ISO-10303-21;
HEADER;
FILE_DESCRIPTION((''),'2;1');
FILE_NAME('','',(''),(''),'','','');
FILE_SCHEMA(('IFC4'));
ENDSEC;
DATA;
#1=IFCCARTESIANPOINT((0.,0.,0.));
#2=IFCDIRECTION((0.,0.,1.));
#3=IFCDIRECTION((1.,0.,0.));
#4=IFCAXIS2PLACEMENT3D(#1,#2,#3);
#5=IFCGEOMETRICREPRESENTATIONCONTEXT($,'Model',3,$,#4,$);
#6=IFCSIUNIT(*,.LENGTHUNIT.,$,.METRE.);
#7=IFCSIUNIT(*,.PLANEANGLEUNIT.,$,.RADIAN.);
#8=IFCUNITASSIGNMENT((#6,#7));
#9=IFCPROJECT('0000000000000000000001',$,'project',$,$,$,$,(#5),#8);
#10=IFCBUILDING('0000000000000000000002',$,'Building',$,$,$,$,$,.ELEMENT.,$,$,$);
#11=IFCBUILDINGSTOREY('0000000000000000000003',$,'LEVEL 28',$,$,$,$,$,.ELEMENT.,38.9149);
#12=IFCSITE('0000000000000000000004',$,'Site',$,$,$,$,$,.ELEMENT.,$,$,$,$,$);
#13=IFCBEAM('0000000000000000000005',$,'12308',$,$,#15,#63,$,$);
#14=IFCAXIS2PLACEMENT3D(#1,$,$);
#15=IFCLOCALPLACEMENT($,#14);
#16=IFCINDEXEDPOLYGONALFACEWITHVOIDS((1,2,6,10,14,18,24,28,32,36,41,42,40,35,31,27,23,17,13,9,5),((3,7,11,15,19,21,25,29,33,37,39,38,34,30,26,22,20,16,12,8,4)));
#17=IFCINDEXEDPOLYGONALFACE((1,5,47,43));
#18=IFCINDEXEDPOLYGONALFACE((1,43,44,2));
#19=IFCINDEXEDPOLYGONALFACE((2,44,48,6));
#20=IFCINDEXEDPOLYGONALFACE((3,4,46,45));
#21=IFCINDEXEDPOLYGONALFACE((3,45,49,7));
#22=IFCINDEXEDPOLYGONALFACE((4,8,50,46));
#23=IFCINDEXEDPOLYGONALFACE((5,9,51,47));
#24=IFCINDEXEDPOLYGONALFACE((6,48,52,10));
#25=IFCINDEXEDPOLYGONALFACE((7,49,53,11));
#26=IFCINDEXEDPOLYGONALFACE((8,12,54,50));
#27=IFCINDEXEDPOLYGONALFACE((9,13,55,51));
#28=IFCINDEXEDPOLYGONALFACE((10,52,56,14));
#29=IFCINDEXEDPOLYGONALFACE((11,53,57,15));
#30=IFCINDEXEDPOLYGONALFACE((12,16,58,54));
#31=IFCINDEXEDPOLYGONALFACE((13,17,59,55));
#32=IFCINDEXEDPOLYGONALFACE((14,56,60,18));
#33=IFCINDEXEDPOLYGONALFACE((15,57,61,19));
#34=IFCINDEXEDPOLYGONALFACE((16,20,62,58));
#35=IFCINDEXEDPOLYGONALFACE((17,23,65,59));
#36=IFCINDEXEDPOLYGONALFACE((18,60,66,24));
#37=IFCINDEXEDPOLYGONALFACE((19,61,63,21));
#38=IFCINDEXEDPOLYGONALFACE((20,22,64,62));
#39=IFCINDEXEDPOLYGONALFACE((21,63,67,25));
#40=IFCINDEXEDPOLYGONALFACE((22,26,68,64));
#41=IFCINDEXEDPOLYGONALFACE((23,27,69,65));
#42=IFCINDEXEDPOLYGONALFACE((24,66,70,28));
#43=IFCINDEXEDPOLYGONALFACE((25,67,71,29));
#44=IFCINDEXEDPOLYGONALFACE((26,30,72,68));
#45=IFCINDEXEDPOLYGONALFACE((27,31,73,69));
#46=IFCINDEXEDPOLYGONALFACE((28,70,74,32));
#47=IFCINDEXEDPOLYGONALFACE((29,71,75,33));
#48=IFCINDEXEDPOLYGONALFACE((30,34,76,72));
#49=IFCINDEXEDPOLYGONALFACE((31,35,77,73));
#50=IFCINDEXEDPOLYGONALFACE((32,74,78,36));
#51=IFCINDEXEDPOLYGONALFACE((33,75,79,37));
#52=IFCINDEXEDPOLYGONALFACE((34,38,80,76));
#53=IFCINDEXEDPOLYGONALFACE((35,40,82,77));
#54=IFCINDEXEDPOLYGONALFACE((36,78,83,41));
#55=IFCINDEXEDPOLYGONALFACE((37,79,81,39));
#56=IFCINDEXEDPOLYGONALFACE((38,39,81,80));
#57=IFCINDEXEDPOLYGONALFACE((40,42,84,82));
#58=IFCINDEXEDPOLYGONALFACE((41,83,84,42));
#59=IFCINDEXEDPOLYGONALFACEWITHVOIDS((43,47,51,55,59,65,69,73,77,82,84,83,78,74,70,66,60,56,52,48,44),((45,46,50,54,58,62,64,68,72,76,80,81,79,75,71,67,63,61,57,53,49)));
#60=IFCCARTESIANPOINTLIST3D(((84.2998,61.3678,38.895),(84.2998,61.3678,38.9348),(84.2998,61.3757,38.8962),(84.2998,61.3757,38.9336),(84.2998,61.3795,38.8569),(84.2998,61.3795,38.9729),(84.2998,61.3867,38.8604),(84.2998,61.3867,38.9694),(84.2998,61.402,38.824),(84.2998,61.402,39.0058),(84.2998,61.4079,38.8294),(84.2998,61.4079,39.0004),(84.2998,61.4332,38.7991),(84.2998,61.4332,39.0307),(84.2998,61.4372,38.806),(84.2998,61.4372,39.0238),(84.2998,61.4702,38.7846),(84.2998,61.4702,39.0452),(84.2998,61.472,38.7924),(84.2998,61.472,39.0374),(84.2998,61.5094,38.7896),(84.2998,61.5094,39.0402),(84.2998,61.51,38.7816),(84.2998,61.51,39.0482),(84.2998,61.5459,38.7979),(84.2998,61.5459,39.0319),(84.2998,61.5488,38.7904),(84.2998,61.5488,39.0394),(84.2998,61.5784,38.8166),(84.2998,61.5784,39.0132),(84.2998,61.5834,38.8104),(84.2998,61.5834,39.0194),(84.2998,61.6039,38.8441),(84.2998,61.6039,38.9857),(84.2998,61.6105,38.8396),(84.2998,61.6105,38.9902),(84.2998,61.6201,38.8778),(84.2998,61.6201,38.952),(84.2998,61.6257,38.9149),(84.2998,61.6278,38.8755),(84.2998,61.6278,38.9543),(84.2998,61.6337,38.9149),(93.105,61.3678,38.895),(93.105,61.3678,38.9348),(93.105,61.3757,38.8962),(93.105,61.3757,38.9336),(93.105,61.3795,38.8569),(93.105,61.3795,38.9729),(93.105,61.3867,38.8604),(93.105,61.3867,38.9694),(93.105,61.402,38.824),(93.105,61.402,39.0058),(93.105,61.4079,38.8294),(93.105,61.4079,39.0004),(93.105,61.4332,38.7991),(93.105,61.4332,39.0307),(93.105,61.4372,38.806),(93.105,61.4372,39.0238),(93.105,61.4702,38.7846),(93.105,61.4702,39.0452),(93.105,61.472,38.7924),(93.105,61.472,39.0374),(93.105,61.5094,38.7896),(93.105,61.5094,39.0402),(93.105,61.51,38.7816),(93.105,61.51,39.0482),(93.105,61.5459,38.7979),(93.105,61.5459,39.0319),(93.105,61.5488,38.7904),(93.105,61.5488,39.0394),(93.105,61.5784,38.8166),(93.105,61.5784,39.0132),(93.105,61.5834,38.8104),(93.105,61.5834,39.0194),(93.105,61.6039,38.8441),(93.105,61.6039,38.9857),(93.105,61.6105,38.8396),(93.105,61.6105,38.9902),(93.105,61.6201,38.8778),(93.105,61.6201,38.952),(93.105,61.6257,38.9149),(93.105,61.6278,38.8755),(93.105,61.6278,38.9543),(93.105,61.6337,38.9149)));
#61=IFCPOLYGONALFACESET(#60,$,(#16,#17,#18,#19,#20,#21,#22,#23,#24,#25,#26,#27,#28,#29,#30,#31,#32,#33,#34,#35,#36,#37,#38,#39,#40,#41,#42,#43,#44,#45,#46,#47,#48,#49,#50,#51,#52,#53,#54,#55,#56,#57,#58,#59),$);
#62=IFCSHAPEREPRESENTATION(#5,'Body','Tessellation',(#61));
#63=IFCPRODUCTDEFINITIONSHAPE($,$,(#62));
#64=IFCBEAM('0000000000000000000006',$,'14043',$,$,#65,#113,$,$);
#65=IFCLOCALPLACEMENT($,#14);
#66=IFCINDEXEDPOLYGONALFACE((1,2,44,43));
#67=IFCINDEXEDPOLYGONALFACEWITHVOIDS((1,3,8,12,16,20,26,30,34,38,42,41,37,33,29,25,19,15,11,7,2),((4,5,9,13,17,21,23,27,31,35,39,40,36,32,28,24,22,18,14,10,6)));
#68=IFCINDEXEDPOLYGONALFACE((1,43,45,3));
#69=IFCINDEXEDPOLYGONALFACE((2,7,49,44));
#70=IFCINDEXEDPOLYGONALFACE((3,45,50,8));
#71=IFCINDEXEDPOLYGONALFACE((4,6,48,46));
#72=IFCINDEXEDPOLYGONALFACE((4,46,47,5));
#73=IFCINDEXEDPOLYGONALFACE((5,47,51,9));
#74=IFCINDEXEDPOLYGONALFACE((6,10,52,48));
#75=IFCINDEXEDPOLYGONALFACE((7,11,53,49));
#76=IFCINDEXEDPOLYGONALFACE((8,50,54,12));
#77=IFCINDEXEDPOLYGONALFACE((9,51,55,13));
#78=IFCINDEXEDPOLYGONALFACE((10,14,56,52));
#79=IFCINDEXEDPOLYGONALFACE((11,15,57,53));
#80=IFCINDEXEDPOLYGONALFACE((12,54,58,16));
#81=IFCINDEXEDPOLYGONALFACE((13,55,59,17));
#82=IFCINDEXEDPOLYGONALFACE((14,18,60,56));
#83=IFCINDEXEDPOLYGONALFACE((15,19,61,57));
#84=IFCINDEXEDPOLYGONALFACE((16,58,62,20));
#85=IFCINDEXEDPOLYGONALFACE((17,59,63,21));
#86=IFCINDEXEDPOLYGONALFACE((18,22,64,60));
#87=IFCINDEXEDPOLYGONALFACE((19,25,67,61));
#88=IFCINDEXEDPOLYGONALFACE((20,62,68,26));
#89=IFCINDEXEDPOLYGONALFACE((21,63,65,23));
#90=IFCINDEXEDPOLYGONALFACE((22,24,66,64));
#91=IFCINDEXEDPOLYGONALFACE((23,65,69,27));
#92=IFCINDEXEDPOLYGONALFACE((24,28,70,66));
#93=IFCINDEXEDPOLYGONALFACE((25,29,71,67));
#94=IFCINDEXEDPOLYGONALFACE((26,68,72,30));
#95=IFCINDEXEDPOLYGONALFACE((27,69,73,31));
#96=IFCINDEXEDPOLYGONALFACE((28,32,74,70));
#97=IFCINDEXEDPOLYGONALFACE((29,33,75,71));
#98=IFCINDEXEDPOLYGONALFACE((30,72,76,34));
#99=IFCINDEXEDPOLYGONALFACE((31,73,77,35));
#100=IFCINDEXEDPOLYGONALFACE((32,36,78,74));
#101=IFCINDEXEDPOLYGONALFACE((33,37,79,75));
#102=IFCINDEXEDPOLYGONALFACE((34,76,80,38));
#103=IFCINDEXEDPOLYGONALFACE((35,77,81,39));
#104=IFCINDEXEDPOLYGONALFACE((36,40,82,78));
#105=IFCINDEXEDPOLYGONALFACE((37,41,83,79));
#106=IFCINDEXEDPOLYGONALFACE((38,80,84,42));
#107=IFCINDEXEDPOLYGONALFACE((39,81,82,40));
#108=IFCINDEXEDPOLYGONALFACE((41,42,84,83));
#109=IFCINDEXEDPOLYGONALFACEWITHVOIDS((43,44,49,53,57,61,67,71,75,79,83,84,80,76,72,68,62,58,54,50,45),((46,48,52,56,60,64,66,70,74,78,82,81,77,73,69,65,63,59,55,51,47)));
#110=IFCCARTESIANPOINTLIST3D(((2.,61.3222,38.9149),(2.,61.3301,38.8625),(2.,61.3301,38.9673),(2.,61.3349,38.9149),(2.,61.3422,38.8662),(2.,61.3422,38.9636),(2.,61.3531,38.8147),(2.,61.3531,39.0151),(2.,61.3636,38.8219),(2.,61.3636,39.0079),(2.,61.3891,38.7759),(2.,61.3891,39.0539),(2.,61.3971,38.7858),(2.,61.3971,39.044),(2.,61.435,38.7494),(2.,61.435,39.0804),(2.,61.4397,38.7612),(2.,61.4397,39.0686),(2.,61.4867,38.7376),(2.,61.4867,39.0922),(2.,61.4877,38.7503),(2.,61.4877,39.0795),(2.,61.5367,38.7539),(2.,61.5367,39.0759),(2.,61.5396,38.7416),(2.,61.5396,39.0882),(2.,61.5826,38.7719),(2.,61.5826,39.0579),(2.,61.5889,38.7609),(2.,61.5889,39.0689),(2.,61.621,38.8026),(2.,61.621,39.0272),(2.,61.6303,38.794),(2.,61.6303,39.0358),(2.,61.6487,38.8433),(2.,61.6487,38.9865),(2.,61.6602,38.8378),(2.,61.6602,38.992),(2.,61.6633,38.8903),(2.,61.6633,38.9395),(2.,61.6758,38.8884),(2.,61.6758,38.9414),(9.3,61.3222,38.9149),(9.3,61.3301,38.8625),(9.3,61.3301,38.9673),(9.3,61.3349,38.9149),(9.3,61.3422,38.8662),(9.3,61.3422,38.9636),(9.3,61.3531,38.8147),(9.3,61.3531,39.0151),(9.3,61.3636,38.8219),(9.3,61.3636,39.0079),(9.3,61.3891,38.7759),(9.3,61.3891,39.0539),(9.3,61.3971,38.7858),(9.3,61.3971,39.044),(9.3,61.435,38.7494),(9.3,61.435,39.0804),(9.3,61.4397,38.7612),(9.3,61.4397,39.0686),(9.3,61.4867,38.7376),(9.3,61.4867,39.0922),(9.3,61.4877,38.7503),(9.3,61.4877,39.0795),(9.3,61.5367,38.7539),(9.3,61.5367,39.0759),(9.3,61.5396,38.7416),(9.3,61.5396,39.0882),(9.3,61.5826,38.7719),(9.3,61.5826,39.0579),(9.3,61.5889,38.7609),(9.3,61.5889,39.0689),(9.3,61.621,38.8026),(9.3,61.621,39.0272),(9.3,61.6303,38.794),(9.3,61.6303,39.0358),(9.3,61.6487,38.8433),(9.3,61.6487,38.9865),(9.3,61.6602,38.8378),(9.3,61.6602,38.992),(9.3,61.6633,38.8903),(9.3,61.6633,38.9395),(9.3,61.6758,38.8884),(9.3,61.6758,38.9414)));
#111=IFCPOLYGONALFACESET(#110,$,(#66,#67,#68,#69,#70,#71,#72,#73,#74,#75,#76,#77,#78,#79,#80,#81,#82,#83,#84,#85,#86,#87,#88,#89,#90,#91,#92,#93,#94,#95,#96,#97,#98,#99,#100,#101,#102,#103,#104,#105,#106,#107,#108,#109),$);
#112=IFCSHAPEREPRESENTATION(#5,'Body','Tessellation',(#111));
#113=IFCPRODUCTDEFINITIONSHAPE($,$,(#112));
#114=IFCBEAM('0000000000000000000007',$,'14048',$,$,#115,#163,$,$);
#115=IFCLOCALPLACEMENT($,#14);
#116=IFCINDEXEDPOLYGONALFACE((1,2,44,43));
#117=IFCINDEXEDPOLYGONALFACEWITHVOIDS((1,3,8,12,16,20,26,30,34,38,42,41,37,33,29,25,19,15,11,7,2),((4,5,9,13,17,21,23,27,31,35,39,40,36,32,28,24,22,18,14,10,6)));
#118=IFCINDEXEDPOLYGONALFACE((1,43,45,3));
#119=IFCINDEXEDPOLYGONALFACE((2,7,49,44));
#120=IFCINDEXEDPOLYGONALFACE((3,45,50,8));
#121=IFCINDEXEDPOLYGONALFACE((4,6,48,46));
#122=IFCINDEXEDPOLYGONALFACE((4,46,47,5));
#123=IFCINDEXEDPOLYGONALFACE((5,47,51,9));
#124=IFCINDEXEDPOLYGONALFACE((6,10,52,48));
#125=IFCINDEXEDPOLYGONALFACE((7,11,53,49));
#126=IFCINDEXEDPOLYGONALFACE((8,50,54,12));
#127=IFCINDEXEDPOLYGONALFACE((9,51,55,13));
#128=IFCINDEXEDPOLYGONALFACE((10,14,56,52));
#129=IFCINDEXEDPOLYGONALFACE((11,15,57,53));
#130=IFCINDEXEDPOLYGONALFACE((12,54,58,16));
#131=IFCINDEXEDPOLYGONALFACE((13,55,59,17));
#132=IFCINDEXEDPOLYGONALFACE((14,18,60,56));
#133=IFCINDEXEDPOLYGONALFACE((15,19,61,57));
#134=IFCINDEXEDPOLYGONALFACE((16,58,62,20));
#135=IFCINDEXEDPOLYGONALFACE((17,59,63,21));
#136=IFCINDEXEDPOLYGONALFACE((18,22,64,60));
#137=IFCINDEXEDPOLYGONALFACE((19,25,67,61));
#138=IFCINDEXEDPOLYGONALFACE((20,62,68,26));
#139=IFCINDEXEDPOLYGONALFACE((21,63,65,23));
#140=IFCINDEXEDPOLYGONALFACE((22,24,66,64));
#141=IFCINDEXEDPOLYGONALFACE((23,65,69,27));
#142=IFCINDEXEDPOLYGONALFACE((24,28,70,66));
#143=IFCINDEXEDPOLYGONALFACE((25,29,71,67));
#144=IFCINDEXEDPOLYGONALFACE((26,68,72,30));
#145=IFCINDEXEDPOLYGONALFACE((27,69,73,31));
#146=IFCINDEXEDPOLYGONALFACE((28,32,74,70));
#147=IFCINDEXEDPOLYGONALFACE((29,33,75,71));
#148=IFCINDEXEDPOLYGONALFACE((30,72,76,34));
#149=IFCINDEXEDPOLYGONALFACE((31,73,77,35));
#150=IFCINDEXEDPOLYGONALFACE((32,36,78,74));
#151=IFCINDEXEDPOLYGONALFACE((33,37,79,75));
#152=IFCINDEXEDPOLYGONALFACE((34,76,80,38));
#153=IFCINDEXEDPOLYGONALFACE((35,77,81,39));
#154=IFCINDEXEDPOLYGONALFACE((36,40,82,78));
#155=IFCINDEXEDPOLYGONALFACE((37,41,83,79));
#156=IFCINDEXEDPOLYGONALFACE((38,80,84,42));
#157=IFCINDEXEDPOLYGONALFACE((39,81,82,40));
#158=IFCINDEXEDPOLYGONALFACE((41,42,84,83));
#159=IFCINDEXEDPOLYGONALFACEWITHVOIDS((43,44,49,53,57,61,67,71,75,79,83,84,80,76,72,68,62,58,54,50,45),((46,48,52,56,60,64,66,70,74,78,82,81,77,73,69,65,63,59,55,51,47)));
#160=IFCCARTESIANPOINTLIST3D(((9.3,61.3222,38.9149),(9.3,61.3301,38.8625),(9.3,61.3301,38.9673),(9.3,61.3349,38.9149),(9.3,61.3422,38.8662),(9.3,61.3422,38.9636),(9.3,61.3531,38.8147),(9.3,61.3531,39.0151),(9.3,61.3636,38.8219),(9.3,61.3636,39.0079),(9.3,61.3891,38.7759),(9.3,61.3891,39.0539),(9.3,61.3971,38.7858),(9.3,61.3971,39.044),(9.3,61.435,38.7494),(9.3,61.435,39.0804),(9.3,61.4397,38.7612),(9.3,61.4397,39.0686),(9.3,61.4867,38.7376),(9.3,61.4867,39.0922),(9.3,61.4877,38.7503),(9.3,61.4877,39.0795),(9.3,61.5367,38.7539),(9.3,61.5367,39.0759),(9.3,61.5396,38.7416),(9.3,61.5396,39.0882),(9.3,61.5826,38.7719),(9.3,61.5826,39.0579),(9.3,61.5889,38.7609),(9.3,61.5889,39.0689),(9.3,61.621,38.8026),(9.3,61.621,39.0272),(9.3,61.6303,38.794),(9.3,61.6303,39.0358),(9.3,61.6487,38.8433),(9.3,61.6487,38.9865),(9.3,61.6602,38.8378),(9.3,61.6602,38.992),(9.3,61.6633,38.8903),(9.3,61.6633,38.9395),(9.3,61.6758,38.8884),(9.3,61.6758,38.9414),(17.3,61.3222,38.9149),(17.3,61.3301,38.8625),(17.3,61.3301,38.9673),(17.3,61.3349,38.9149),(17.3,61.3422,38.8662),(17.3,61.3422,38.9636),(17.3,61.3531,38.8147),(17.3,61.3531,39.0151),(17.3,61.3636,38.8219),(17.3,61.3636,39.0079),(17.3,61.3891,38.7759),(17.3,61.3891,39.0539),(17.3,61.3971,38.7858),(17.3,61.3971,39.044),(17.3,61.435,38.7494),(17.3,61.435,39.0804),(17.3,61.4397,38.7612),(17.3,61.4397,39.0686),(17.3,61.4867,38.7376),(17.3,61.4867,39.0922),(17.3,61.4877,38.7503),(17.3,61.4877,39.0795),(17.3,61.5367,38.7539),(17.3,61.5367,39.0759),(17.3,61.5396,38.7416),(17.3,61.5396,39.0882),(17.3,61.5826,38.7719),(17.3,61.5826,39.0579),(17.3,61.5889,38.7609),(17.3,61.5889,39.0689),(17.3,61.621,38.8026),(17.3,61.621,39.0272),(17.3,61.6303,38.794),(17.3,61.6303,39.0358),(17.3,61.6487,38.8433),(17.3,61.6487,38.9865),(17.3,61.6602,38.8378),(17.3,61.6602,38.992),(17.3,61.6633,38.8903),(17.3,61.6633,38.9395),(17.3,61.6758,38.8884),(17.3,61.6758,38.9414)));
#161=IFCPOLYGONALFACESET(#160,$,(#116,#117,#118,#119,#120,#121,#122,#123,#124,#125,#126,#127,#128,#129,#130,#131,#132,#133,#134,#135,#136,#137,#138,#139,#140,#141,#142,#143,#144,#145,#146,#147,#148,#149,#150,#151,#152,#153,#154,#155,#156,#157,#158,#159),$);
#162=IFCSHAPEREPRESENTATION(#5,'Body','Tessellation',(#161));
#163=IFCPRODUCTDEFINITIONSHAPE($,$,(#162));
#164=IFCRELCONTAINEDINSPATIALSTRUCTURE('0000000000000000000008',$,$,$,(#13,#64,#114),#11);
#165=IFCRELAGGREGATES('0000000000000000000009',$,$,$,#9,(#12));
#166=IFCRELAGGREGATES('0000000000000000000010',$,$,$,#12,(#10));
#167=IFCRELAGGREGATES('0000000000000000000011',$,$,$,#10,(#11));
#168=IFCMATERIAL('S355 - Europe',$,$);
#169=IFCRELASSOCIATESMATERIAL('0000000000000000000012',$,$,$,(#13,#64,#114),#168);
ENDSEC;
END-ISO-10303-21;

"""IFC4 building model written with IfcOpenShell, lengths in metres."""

from ifc_helpers import new_model, si_unit, frame, origin_with_axes, origin_2d_with_axis, place, context, project, spatial, hollow_circle, extrude, material, material_profile, profile_set, profile_usage, element, save


model = new_model("IFC4")

# Units and contexts
model_context = context("Model", 3, world=origin_with_axes())
ifc_project = project(units=[si_unit("LENGTHUNIT", "METRE"), si_unit("PLANEANGLEUNIT", "RADIAN")], contexts=[model_context])

# Site, building, storey
site = spatial("IfcSite", under=ifc_project, Name="Site", CompositionType="ELEMENT")
building = spatial("IfcBuilding", under=site, Name="Building", CompositionType="ELEMENT")
storey = spatial("IfcBuildingStorey", under=building, Name="LEVEL 28", CompositionType="ELEMENT", Elevation=38.9149)

# Beams
ifc_material = material(Name="S355 - Europe")
ifc_material_profile_1 = material_profile(ifc_material, hollow_circle(Radius=0.1337, WallThickness=0.008, at=origin_2d_with_axis()))
ifc_profile_set_1 = profile_set([ifc_material_profile_1])
ifc_profile_usage_1 = profile_usage(ifc_profile_set_1, cardinal=10)
beam_1_placement = place(None, frame((84.2998, 61.5, 38.9149), z_axis=(1.0, 0.0, 0.0), x_axis=(0.0, 1.0, 0.0)))
element("IfcBeam", 1, at=beam_1_placement, inside=storey, material=ifc_profile_usage_1, Name="12308", context=model_context, shape_type="SweptSolid", body=[
    extrude(hollow_circle(Radius=0.1337, WallThickness=0.008, at=origin_2d_with_axis()), origin_with_axes(), (0.0, 0.0, 1.0), 8.8052),
])
ifc_material_profile_2 = material_profile(ifc_material, hollow_circle(Radius=0.1778, WallThickness=0.0127, at=origin_2d_with_axis()))
ifc_profile_set_2 = profile_set([ifc_material_profile_2])
ifc_profile_usage_2 = profile_usage(ifc_profile_set_2, cardinal=10)
beam_2_placement = place(None, frame((9.3, 61.5, 38.9149), z_axis=(-1.0, 0.0, 0.0), x_axis=(0.0, -1.0, 0.0)))
element("IfcBeam", 2, at=beam_2_placement, inside=storey, material=ifc_profile_usage_2, Name="14043", context=model_context, shape_type="SweptSolid", body=[
    extrude(hollow_circle(Radius=0.1778, WallThickness=0.0127, at=origin_2d_with_axis()), origin_with_axes(), (0.0, 0.0, 1.0), 7.3),
])
ifc_material_profile_3 = material_profile(ifc_material, hollow_circle(Radius=0.1778, WallThickness=0.0127, at=origin_2d_with_axis()))
ifc_profile_set_3 = profile_set([ifc_material_profile_3])
ifc_profile_usage_3 = profile_usage(ifc_profile_set_3, cardinal=10)
beam_3_placement = place(None, frame((17.3, 61.5, 38.9149), z_axis=(-1.0, 0.0, 0.0), x_axis=(0.0, -1.0, 0.0)))
element("IfcBeam", 3, at=beam_3_placement, inside=storey, material=ifc_profile_usage_3, Name="14048", context=model_context, shape_type="SweptSolid", body=[
    extrude(hollow_circle(Radius=0.1778, WallThickness=0.0127, at=origin_2d_with_axis()), origin_with_axes(), (0.0, 0.0, 1.0), 8.0),
])

save(model, "model.ifc")
